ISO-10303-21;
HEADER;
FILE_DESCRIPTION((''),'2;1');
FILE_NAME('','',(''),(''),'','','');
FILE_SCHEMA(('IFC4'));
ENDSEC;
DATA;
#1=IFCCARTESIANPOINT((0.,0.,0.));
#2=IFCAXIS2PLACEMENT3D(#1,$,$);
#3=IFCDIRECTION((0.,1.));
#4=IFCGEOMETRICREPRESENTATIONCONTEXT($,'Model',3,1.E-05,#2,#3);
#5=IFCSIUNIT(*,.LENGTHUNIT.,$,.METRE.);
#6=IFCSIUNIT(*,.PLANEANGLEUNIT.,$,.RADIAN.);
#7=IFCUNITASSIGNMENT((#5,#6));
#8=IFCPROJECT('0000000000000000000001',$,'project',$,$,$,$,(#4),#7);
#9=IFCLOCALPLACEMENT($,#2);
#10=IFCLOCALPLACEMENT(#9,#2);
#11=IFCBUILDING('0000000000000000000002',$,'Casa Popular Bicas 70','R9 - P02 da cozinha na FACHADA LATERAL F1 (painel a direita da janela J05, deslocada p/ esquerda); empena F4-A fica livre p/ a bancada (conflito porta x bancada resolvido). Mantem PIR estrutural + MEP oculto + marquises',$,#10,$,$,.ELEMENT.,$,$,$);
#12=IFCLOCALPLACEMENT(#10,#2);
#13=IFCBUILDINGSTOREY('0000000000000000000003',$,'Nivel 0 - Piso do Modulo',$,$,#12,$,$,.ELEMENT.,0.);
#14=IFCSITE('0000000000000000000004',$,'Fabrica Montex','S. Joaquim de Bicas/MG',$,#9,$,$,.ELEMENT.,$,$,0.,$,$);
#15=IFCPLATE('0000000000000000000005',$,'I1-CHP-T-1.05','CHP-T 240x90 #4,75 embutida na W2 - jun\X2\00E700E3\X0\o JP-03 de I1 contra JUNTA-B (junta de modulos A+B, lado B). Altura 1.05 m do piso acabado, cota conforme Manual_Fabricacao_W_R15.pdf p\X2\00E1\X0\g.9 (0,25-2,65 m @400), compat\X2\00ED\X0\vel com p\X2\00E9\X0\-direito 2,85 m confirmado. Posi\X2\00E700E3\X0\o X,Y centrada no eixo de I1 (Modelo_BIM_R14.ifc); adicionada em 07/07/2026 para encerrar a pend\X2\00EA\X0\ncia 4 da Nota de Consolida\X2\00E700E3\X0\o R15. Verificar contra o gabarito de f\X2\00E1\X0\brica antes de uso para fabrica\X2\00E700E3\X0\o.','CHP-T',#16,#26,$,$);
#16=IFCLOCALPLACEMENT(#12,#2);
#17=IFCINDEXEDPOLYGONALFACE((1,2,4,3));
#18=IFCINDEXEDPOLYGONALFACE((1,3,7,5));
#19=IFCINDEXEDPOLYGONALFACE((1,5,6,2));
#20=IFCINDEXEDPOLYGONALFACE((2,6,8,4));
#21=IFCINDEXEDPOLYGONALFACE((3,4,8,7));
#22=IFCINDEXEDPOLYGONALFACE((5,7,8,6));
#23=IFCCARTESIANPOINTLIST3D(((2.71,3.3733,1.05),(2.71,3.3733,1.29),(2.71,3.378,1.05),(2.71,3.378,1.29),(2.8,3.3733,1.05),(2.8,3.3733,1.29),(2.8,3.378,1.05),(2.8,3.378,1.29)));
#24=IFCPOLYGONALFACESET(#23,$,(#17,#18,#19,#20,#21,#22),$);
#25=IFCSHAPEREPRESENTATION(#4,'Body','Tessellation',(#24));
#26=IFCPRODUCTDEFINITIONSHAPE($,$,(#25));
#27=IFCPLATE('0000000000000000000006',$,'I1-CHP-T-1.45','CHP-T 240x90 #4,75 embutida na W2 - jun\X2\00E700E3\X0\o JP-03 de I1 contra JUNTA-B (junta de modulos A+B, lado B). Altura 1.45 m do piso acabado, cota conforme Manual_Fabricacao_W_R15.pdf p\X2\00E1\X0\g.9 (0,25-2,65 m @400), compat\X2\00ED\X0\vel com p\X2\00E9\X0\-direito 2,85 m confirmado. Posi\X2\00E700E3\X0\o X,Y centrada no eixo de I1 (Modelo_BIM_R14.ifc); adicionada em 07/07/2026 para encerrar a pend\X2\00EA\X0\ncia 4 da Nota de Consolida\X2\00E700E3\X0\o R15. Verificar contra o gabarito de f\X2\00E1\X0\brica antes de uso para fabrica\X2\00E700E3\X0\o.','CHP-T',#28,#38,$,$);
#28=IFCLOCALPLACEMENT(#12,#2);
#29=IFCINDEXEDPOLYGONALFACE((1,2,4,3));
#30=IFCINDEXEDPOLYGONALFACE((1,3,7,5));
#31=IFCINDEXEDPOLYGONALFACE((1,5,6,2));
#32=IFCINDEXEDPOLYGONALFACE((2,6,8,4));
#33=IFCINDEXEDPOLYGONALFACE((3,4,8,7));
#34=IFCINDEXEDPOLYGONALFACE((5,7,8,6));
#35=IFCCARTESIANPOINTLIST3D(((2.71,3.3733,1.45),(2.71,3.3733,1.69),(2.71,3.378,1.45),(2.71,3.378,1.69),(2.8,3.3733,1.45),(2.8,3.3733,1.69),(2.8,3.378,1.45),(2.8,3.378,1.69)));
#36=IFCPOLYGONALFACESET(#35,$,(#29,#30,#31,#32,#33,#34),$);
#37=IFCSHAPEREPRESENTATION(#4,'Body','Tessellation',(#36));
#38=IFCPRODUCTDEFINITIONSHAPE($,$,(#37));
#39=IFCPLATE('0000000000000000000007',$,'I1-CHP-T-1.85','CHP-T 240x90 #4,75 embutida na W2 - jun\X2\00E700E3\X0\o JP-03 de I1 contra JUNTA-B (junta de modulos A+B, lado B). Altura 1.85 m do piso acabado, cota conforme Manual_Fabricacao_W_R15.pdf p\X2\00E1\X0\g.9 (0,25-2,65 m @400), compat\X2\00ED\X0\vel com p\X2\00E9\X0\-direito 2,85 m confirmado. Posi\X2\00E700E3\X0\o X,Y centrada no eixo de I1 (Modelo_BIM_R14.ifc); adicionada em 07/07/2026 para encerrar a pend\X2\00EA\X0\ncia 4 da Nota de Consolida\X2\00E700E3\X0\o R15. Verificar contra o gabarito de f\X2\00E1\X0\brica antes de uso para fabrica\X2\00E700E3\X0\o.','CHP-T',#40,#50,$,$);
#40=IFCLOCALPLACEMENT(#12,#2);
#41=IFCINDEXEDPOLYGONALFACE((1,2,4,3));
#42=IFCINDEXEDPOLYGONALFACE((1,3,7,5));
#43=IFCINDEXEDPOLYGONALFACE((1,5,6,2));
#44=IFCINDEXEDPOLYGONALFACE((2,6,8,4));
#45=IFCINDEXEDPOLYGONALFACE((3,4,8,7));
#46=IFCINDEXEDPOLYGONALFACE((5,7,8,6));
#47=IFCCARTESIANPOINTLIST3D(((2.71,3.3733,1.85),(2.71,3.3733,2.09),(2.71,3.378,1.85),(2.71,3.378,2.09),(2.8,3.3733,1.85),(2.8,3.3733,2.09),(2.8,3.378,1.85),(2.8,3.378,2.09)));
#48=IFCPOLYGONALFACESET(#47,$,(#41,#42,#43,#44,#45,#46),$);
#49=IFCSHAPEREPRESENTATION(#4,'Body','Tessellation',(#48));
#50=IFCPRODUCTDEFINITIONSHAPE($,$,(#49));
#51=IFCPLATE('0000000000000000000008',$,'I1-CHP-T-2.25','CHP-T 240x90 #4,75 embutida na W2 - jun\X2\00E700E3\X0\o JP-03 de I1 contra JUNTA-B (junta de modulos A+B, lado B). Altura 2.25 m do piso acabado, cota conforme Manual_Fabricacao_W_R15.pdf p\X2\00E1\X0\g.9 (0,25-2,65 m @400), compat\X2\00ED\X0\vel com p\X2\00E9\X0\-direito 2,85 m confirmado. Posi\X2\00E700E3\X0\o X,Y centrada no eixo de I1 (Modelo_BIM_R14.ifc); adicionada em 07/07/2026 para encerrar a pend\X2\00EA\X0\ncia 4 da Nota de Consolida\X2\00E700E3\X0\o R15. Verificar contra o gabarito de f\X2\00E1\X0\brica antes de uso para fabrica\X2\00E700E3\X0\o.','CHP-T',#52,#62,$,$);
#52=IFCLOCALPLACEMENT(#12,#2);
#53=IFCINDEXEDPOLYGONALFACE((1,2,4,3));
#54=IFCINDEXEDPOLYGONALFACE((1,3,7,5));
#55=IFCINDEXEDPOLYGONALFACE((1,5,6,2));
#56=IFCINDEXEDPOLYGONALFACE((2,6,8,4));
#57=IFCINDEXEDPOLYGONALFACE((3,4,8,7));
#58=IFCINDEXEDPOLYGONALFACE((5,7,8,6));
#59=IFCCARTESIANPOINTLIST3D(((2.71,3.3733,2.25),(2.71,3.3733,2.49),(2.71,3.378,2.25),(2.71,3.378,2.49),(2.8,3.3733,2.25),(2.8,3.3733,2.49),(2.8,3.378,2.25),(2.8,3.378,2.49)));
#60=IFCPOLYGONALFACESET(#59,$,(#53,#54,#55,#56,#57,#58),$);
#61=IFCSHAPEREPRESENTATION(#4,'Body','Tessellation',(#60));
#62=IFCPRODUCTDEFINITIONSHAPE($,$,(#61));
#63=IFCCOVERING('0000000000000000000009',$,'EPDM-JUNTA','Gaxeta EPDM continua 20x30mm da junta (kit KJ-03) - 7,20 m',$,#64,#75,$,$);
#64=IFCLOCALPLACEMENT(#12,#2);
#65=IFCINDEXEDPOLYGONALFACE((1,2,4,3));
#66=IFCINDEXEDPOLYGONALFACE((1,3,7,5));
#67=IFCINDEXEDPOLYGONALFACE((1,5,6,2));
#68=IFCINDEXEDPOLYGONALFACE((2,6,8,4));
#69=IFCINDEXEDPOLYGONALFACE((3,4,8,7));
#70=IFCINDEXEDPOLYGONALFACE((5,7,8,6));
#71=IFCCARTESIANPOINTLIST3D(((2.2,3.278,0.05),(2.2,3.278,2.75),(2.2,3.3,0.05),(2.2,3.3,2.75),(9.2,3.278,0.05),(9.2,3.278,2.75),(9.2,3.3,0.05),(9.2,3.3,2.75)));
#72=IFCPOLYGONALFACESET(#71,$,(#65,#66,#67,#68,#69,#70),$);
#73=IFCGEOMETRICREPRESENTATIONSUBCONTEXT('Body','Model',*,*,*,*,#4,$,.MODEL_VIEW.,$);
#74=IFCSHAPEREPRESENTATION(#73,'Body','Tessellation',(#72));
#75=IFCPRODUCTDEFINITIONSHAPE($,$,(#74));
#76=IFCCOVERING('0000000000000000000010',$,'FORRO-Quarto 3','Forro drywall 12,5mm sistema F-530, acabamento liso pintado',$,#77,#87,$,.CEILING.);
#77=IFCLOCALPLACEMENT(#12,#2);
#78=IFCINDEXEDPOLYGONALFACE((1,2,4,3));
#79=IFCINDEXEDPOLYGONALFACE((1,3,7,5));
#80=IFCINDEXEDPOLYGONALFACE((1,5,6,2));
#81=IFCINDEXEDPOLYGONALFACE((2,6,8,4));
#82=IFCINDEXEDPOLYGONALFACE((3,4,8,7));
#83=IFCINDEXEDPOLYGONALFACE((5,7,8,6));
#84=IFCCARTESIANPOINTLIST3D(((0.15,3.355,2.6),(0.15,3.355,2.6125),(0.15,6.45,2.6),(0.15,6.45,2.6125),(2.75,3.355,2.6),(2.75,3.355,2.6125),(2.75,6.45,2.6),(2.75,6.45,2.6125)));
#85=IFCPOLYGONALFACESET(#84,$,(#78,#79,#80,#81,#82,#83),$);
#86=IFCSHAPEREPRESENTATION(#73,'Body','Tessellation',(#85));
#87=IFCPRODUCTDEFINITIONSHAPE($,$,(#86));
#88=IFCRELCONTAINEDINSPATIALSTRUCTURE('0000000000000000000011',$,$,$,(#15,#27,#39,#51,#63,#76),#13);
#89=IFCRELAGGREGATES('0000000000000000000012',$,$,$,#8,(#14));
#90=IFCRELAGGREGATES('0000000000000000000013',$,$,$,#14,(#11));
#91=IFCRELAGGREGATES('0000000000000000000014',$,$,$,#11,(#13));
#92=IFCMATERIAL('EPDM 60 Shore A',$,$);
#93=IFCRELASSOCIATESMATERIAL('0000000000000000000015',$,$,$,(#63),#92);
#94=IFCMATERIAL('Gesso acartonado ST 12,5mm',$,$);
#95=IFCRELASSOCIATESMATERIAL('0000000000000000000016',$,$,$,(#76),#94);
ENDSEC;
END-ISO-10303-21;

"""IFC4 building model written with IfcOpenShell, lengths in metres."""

from ifc_helpers import new_model, si_unit, direction, frame, frame_2d, origin, origin_with_axes, origin_2d, place, context, subcontext, project, spatial, rectangle, extrude, material, element, save


model = new_model("IFC4")

# Units and contexts
model_context = context("Model", 3, precision=1e-05, world=origin(), true_north=direction((0.0, 1.0)))
body_context = subcontext(model_context, "Body", "Model", "MODEL_VIEW")
ifc_project = project(units=[si_unit("LENGTHUNIT", "METRE"), si_unit("PLANEANGLEUNIT", "RADIAN")], contexts=[model_context])

# Site, building, storey
site_placement = place(None, origin())
site = spatial("IfcSite", under=ifc_project, at=site_placement, Name="Fabrica Montex", Description="S. Joaquim de Bicas/MG", CompositionType="ELEMENT", RefElevation=0.0)
building_placement = place(site_placement, origin())
building = spatial("IfcBuilding", under=site, at=building_placement, Name="Casa Popular Bicas 70", Description="R9 - P02 da cozinha na FACHADA LATERAL F1 (painel a direita da janela J05, deslocada p/ esquerda); empena F4-A fica livre p/ a bancada (conflito porta x bancada resolvido). Mantem PIR estrutural + MEP oculto + marquises", CompositionType="ELEMENT")
storey_placement = place(building_placement, origin())
storey = spatial("IfcBuildingStorey", under=building, at=storey_placement, Name="Nivel 0 - Piso do Modulo", CompositionType="ELEMENT", Elevation=0.0)

# Plates
for number, where, z_axis, x_axis, name, description in (
    (1, (2.755, 3.3756, 1.05), (0.0, 0.0, 1.0), (1.0, 0.0, 0.0), "I1-CHP-T-1.05", "CHP-T 240x90 #4,75 embutida na W2 - junção JP-03 de I1 contra JUNTA-B (junta de modulos A+B, lado B). Altura 1.05 m do piso acabado, cota conforme Manual_Fabricacao_W_R15.pdf pág.9 (0,25-2,65 m @400), compatível com pé-direito 2,85 m confirmado. Posição X,Y centrada no eixo de I1 (Modelo_BIM_R14.ifc); adicionada em 07/07/2026 para encerrar a pendência 4 da Nota de Consolidação R15. Verificar contra o gabarito de fábrica antes de uso para fabricação."),
    (2, (2.755, 3.3756, 1.45), (0.0, 0.0, 1.0), (1.0, 0.0, 0.0), "I1-CHP-T-1.45", "CHP-T 240x90 #4,75 embutida na W2 - junção JP-03 de I1 contra JUNTA-B (junta de modulos A+B, lado B). Altura 1.45 m do piso acabado, cota conforme Manual_Fabricacao_W_R15.pdf pág.9 (0,25-2,65 m @400), compatível com pé-direito 2,85 m confirmado. Posição X,Y centrada no eixo de I1 (Modelo_BIM_R14.ifc); adicionada em 07/07/2026 para encerrar a pendência 4 da Nota de Consolidação R15. Verificar contra o gabarito de fábrica antes de uso para fabricação."),
    (3, (2.755, 3.3756, 1.85), (0.0, 0.0, 1.0), (1.0, 0.0, 0.0), "I1-CHP-T-1.85", "CHP-T 240x90 #4,75 embutida na W2 - junção JP-03 de I1 contra JUNTA-B (junta de modulos A+B, lado B). Altura 1.85 m do piso acabado, cota conforme Manual_Fabricacao_W_R15.pdf pág.9 (0,25-2,65 m @400), compatível com pé-direito 2,85 m confirmado. Posição X,Y centrada no eixo de I1 (Modelo_BIM_R14.ifc); adicionada em 07/07/2026 para encerrar a pendência 4 da Nota de Consolidação R15. Verificar contra o gabarito de fábrica antes de uso para fabricação."),
    (4, (2.755, 3.3756, 2.25), (0.0, 0.0, 1.0), (1.0, 0.0, 0.0), "I1-CHP-T-2.25", "CHP-T 240x90 #4,75 embutida na W2 - junção JP-03 de I1 contra JUNTA-B (junta de modulos A+B, lado B). Altura 2.25 m do piso acabado, cota conforme Manual_Fabricacao_W_R15.pdf pág.9 (0,25-2,65 m @400), compatível com pé-direito 2,85 m confirmado. Posição X,Y centrada no eixo de I1 (Modelo_BIM_R14.ifc); adicionada em 07/07/2026 para encerrar a pendência 4 da Nota de Consolidação R15. Verificar contra o gabarito de fábrica antes de uso para fabricação."),
):
    element("IfcPlate", number, at=place(storey_placement, frame(where, z_axis=z_axis, x_axis=x_axis)), inside=storey, Name=name, Description=description, ObjectType="CHP-T", context=model_context, shape_type="SweptSolid", body=[
        extrude(rectangle(XDim=0.09, YDim=0.0047, at=origin_2d()), origin_with_axes(), (0.0, 0.0, 1.0), 0.24),
    ])

# Coverings
ifc_material_1 = material(Name="EPDM 60 Shore A")
covering_1_placement = place(storey_placement, frame((2.2, 3.289, 0.05), x_axis=(1.0, 0.0, 0.0)))
element("IfcCovering", 5, at=covering_1_placement, inside=storey, material=ifc_material_1, Name="EPDM-JUNTA", Description="Gaxeta EPDM continua 20x30mm da junta (kit KJ-03) - 7,20 m", context=body_context, shape_type="SweptSolid", body=[
    extrude(rectangle(XDim=7.0, YDim=0.022, at=frame_2d((3.5, 0.0))), origin(), (0.0, 0.0, 1.0), 2.7),
])
ifc_material_2 = material(Name="Gesso acartonado ST 12,5mm")
covering_2_placement = place(storey_placement, frame((0.15, 3.355, 2.6)))
element("IfcCovering", 6, at=covering_2_placement, inside=storey, material=ifc_material_2, Name="FORRO-Quarto 3", Description="Forro drywall 12,5mm sistema F-530, acabamento liso pintado", PredefinedType="CEILING", context=body_context, shape_type="SweptSolid", body=[
    extrude(rectangle(XDim=2.6, YDim=3.095, at=frame_2d((1.3, 1.5475))), origin(), (0.0, 0.0, 1.0), 0.0125),
])

save(model, "model.ifc")
